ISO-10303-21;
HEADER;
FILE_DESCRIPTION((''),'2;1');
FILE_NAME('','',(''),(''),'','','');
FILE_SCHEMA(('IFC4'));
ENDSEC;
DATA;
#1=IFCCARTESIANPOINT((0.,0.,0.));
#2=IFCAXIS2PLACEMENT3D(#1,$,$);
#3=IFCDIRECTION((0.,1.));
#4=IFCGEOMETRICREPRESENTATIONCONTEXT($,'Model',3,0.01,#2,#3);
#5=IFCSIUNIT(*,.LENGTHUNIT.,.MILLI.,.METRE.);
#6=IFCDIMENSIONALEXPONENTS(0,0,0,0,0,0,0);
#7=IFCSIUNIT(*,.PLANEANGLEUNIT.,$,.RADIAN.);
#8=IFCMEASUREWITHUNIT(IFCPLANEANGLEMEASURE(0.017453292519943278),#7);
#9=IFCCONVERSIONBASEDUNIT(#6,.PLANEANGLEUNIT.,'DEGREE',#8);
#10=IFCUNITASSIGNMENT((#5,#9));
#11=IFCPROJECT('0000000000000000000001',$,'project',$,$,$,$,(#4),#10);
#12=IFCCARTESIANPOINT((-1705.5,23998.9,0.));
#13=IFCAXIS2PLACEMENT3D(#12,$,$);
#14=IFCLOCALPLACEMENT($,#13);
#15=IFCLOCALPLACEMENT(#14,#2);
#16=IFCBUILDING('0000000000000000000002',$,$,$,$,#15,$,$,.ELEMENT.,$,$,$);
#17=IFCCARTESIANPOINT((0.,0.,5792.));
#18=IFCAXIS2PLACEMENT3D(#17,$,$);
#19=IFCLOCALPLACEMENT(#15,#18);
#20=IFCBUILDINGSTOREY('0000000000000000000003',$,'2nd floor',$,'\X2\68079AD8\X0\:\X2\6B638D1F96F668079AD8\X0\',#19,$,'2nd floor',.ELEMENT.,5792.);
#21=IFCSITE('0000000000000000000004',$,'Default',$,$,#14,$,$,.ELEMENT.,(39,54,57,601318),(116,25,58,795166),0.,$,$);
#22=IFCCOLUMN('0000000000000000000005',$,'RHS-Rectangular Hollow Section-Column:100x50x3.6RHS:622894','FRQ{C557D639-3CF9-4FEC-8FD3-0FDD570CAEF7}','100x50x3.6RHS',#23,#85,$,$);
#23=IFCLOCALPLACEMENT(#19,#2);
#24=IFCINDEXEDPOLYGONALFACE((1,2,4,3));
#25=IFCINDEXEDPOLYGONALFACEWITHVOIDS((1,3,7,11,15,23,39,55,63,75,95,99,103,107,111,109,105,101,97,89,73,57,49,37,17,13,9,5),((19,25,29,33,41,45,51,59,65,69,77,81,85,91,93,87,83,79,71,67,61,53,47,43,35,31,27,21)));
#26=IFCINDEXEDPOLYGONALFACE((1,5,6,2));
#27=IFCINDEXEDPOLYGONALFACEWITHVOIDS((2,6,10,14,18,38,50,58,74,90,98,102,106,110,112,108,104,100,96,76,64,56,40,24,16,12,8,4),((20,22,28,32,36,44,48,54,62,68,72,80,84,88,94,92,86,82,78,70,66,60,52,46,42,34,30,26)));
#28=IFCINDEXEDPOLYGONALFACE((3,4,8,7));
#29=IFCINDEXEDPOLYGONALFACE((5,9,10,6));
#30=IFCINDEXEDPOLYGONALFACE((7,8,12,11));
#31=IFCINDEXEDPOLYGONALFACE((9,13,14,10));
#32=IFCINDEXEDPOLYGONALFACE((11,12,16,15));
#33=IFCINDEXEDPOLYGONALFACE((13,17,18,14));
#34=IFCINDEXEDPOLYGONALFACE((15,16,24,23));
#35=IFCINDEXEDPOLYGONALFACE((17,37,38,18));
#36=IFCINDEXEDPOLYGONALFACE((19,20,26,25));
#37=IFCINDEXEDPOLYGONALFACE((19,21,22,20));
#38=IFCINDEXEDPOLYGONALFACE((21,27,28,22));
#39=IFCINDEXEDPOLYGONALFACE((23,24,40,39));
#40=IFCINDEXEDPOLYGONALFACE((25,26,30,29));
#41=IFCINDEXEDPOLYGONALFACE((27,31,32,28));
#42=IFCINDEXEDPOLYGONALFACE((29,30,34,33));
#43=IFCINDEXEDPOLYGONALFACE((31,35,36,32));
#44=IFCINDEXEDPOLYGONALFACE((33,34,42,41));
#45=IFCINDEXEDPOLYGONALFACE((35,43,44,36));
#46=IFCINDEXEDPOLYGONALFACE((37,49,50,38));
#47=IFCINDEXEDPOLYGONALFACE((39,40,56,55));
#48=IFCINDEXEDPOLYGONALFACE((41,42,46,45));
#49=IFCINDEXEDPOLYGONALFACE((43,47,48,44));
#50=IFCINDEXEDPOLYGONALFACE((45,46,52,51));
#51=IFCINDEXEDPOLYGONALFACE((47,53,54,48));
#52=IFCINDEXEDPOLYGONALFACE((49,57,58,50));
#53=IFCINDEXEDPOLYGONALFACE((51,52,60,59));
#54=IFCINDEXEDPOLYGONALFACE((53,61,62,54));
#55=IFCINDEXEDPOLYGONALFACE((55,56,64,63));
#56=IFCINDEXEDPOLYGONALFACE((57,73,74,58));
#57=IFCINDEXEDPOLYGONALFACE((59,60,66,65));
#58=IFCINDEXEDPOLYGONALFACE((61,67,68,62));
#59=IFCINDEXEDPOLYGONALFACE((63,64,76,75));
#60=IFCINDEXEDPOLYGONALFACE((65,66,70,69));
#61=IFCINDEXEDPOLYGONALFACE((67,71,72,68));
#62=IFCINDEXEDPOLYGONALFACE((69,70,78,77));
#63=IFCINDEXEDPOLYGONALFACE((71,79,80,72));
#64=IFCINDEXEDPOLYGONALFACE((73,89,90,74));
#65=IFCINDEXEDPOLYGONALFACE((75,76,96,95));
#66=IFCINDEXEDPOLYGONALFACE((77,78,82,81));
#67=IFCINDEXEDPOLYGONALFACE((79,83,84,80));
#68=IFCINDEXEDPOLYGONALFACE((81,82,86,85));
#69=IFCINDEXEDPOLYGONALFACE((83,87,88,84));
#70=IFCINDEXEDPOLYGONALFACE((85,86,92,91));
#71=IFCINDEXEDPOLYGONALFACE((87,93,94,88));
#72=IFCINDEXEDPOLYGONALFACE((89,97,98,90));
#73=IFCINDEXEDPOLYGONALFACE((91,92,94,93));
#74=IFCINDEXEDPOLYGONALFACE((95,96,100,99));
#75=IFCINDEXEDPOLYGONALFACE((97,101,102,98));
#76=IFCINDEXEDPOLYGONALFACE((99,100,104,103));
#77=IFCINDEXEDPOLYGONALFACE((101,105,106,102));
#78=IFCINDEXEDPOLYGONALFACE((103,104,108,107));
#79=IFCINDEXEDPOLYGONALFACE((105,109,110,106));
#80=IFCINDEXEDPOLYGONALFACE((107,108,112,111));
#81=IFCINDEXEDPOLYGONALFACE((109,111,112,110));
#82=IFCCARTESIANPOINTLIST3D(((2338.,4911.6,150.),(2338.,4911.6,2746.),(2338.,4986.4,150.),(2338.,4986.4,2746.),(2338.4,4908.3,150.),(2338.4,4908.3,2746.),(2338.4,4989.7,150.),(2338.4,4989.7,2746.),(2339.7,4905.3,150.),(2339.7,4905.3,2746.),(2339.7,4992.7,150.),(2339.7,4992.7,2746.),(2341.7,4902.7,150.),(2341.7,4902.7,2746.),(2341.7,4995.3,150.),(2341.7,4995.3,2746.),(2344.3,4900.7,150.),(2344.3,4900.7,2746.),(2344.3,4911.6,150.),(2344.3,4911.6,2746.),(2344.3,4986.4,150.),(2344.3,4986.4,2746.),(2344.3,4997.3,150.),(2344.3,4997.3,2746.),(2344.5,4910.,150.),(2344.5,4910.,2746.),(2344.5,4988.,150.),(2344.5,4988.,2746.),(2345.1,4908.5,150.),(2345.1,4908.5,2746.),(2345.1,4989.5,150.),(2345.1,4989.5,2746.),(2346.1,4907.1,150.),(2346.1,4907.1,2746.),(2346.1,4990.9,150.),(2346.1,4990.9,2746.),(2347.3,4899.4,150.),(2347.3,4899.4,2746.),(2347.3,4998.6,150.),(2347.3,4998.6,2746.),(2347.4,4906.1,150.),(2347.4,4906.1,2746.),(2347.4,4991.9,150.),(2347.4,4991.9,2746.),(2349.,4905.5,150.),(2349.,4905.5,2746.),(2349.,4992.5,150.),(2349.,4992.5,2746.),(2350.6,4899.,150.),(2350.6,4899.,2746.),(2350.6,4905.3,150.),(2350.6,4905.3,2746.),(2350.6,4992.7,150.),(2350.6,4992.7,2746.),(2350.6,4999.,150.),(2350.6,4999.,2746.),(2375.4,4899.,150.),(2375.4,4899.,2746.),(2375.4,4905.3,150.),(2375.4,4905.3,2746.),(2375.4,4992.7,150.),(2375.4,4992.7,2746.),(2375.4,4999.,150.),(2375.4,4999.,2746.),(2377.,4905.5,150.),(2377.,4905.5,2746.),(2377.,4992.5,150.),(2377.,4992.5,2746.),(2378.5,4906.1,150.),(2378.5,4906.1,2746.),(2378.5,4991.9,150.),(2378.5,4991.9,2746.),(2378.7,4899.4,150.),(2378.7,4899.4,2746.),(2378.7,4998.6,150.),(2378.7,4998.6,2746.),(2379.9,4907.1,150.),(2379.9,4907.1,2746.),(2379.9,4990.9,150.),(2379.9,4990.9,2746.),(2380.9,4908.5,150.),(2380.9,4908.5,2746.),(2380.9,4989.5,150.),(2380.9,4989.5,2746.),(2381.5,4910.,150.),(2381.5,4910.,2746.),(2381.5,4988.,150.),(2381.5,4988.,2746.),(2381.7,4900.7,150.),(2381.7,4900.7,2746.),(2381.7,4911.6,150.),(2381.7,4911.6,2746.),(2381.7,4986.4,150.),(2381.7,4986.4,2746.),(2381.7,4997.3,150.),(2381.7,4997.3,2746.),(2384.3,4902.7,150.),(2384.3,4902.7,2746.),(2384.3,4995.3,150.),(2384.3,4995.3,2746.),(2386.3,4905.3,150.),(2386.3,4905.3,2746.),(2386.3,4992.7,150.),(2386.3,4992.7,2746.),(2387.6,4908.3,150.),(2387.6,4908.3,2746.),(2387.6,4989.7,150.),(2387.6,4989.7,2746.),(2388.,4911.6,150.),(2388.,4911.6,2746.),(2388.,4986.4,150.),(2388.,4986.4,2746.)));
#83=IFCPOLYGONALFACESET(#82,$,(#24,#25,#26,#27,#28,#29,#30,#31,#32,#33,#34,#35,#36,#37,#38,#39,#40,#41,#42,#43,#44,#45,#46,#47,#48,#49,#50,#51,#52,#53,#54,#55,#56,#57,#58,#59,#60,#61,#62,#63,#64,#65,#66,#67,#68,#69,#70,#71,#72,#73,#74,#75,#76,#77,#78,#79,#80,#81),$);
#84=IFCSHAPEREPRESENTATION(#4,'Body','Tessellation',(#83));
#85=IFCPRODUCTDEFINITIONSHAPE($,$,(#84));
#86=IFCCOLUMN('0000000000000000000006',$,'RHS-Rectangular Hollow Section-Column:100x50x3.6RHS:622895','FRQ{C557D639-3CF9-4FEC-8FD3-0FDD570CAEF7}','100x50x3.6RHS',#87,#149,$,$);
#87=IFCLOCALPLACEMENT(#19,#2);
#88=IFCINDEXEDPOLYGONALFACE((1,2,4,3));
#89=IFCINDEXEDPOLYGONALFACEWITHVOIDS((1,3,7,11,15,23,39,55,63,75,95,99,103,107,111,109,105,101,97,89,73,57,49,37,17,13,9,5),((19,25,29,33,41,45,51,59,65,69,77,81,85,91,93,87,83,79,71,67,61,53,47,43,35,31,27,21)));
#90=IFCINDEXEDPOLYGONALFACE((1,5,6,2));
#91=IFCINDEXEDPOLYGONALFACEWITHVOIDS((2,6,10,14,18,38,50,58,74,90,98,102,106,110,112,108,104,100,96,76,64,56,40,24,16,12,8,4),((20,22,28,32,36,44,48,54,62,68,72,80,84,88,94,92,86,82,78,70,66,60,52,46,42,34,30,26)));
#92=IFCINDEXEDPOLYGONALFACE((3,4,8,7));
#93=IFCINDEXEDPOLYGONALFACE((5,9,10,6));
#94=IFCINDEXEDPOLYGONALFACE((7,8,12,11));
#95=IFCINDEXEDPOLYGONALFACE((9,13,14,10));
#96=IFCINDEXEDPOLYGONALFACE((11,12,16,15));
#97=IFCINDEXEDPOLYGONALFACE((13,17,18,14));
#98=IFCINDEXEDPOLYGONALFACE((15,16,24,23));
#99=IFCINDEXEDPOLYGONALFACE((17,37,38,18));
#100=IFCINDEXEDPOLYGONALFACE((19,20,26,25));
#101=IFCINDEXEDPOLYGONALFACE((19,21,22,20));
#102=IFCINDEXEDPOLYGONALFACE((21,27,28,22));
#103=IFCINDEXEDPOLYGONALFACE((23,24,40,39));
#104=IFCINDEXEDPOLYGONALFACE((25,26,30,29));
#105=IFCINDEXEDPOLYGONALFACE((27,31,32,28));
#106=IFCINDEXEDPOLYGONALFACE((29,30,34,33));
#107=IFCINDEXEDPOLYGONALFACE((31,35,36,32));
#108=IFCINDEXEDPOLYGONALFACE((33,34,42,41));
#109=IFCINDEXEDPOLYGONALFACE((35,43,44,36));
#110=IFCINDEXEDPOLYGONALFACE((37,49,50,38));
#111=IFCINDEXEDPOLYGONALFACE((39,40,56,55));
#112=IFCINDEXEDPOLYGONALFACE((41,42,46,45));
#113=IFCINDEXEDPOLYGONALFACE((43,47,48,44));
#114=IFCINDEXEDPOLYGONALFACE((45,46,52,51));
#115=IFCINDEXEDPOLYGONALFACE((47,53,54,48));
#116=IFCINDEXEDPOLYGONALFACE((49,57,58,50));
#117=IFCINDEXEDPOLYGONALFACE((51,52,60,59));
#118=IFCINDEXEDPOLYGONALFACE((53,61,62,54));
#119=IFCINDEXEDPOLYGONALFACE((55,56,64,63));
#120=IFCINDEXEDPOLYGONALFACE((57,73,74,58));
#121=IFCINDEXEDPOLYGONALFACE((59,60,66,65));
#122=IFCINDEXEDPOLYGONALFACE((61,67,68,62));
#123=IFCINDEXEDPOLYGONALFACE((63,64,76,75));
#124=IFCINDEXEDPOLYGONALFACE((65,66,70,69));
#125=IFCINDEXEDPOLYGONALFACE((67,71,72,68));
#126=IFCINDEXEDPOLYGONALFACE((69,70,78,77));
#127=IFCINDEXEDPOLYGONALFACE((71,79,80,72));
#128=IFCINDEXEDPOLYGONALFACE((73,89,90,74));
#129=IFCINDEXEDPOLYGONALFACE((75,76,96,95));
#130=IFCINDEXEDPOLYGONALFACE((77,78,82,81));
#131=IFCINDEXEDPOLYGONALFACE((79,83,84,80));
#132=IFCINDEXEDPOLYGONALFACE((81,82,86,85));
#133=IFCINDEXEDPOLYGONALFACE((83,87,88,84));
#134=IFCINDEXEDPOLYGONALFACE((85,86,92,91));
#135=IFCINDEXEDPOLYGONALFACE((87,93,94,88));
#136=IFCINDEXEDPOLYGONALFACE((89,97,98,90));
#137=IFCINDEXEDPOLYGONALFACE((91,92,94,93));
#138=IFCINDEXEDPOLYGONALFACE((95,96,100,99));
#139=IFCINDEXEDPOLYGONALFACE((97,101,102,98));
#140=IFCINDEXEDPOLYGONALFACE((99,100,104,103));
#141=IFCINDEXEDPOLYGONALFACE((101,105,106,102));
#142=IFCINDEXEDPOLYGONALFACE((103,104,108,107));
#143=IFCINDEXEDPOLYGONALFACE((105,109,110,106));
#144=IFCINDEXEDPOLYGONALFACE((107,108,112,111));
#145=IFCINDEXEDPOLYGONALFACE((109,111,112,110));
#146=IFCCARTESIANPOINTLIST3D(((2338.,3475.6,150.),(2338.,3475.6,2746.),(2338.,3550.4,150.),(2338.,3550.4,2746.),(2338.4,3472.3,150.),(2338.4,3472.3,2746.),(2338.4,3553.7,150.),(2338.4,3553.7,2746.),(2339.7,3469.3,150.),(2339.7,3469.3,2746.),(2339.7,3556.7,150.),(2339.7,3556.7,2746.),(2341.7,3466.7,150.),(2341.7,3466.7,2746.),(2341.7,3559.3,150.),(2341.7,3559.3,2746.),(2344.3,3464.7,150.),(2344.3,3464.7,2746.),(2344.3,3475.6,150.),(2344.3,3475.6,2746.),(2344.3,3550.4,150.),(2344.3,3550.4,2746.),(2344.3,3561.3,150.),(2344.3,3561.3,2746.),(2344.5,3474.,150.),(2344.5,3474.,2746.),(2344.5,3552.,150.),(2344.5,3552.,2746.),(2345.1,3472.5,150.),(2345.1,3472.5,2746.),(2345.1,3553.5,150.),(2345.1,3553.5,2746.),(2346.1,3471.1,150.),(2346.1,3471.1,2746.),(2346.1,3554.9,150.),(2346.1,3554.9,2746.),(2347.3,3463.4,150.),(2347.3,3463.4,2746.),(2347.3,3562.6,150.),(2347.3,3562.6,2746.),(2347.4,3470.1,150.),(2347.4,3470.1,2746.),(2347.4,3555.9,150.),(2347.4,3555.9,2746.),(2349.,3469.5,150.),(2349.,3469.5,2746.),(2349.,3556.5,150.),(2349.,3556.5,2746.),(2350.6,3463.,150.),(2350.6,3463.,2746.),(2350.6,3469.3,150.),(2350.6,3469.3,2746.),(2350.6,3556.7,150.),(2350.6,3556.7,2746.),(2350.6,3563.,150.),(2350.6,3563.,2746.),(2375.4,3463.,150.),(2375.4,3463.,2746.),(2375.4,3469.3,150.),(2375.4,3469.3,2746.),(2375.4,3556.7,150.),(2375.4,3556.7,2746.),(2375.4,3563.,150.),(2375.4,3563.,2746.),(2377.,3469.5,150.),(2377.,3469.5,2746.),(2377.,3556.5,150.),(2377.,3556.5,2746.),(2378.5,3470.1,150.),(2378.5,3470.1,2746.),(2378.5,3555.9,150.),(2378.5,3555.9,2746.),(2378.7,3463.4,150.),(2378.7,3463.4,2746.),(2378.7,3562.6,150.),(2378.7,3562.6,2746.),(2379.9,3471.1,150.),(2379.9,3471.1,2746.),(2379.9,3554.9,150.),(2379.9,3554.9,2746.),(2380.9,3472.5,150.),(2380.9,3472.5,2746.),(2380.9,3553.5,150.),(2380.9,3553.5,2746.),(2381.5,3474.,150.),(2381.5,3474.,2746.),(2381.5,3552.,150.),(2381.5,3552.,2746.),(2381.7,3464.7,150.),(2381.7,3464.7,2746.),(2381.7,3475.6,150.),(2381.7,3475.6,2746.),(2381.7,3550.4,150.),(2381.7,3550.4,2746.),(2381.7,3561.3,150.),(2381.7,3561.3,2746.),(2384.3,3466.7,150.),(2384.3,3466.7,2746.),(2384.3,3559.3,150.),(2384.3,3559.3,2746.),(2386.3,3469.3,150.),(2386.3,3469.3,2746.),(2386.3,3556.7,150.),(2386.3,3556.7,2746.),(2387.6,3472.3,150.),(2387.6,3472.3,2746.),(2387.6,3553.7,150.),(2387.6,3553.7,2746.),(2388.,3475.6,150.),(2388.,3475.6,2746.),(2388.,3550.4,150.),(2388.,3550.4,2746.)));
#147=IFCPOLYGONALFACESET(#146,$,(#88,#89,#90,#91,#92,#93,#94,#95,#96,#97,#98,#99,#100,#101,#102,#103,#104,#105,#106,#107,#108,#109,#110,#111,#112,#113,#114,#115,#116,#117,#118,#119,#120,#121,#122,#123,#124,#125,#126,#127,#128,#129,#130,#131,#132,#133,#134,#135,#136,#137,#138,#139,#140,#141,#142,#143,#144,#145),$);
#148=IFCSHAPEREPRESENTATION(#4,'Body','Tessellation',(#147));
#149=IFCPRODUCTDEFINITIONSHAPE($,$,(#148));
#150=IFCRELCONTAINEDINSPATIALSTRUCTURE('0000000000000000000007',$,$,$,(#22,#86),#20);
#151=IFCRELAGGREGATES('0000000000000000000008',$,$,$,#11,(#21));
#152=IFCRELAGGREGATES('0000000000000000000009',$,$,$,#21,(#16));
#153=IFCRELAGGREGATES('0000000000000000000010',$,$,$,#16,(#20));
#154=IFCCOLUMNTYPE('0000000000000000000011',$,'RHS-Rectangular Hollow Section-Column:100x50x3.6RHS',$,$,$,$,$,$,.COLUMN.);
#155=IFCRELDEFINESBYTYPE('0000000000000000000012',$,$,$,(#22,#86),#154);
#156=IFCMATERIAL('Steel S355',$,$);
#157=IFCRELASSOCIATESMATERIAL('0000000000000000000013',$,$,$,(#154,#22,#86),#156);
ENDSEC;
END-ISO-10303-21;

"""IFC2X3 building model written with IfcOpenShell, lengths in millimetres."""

from ifc_helpers import new_model, entity, si_unit, converted_unit, direction, frame, origin, origin_2d, place, context, project, spatial, hollow_rectangle, extrude, clip, halfspace, material, type_object, element, save


model = new_model("IFC2X3")

# Units and contexts
model_context = context("Model", 3, precision=0.01, world=origin(), true_north=direction((0.0, 1.0)))
ifc_project = project(units=[si_unit("LENGTHUNIT", "METRE", prefix="MILLI"), converted_unit("PLANEANGLEUNIT", "DEGREE", entity("IfcPlaneAngleMeasure", 0.017453292519943278), si_unit("PLANEANGLEUNIT", "RADIAN"), dimensions=[0, 0, 0, 0, 0, 0, 0])], contexts=[model_context])

# Site, building, storey
site_placement = place(None, frame((-1705.5, 23998.9, 0.0)))
site = spatial("IfcSite", under=ifc_project, at=site_placement, Name="Default", CompositionType="ELEMENT", RefLatitude=(39, 54, 57, 601318), RefLongitude=(116, 25, 58, 795166), RefElevation=0.0)
building_placement = place(site_placement, origin())
building = spatial("IfcBuilding", under=site, at=building_placement, CompositionType="ELEMENT")
storey_placement = place(building_placement, frame((0.0, 0.0, 5792.0)))
storey = spatial("IfcBuildingStorey", under=building, at=storey_placement, Name="2nd floor", ObjectType="标高:正负零标高", LongName="2nd floor", CompositionType="ELEMENT", Elevation=5792.0)

# Shared definitions
ifc_material_1 = material(Name="Steel S355")

# Columns
column_type_1 = type_object("IfcColumnType", Name="RHS-Rectangular Hollow Section-Column:100x50x3.6RHS", PredefinedType="COLUMN", material=ifc_material_1)
column_1_placement = place(storey_placement, frame((2363.0, 4949.0, 2746.0), z_axis=(0.0, 0.0, 1.0), x_axis=(-1.0, 0.0, 0.0)))
element("IfcColumn", 1, at=column_1_placement, inside=storey, type_object=column_type_1, material=ifc_material_1, Name="RHS-Rectangular Hollow Section-Column:100x50x3.6RHS:622894", Description="FRQ{C557D639-3CF9-4FEC-8FD3-0FDD570CAEF7}", ObjectType="100x50x3.6RHS", context=model_context, shape_type="Clipping", body=[
    clip(extrude(hollow_rectangle(XDim=50.0, YDim=100.0, WallThickness=6.3, InnerFilletRadius=6.3, OuterFilletRadius=12.6, at=origin_2d()), origin(), (0.0, 0.0, -1.0), 2651.9), halfspace(frame((2363.0, 4949.0, -2596.0), z_axis=(0.0, 0.0, 1.0), x_axis=(-1.0, 0.0, 0.0)), True)),
])
column_2_placement = place(storey_placement, frame((2363.0, 3513.0, 2746.0), z_axis=(0.0, 0.0, 1.0), x_axis=(-1.0, 0.0, 0.0)))
element("IfcColumn", 2, at=column_2_placement, inside=storey, type_object=column_type_1, material=ifc_material_1, Name="RHS-Rectangular Hollow Section-Column:100x50x3.6RHS:622895", Description="FRQ{C557D639-3CF9-4FEC-8FD3-0FDD570CAEF7}", ObjectType="100x50x3.6RHS", context=model_context, shape_type="Clipping", body=[
    clip(extrude(hollow_rectangle(XDim=50.0, YDim=100.0, WallThickness=6.3, InnerFilletRadius=6.3, OuterFilletRadius=12.6, at=origin_2d()), origin(), (0.0, 0.0, -1.0), 2651.9), halfspace(frame((2363.0, 3513.0, -2596.0), z_axis=(0.0, 0.0, 1.0), x_axis=(-1.0, 0.0, 0.0)), True)),
])

save(model, "model.ifc")
